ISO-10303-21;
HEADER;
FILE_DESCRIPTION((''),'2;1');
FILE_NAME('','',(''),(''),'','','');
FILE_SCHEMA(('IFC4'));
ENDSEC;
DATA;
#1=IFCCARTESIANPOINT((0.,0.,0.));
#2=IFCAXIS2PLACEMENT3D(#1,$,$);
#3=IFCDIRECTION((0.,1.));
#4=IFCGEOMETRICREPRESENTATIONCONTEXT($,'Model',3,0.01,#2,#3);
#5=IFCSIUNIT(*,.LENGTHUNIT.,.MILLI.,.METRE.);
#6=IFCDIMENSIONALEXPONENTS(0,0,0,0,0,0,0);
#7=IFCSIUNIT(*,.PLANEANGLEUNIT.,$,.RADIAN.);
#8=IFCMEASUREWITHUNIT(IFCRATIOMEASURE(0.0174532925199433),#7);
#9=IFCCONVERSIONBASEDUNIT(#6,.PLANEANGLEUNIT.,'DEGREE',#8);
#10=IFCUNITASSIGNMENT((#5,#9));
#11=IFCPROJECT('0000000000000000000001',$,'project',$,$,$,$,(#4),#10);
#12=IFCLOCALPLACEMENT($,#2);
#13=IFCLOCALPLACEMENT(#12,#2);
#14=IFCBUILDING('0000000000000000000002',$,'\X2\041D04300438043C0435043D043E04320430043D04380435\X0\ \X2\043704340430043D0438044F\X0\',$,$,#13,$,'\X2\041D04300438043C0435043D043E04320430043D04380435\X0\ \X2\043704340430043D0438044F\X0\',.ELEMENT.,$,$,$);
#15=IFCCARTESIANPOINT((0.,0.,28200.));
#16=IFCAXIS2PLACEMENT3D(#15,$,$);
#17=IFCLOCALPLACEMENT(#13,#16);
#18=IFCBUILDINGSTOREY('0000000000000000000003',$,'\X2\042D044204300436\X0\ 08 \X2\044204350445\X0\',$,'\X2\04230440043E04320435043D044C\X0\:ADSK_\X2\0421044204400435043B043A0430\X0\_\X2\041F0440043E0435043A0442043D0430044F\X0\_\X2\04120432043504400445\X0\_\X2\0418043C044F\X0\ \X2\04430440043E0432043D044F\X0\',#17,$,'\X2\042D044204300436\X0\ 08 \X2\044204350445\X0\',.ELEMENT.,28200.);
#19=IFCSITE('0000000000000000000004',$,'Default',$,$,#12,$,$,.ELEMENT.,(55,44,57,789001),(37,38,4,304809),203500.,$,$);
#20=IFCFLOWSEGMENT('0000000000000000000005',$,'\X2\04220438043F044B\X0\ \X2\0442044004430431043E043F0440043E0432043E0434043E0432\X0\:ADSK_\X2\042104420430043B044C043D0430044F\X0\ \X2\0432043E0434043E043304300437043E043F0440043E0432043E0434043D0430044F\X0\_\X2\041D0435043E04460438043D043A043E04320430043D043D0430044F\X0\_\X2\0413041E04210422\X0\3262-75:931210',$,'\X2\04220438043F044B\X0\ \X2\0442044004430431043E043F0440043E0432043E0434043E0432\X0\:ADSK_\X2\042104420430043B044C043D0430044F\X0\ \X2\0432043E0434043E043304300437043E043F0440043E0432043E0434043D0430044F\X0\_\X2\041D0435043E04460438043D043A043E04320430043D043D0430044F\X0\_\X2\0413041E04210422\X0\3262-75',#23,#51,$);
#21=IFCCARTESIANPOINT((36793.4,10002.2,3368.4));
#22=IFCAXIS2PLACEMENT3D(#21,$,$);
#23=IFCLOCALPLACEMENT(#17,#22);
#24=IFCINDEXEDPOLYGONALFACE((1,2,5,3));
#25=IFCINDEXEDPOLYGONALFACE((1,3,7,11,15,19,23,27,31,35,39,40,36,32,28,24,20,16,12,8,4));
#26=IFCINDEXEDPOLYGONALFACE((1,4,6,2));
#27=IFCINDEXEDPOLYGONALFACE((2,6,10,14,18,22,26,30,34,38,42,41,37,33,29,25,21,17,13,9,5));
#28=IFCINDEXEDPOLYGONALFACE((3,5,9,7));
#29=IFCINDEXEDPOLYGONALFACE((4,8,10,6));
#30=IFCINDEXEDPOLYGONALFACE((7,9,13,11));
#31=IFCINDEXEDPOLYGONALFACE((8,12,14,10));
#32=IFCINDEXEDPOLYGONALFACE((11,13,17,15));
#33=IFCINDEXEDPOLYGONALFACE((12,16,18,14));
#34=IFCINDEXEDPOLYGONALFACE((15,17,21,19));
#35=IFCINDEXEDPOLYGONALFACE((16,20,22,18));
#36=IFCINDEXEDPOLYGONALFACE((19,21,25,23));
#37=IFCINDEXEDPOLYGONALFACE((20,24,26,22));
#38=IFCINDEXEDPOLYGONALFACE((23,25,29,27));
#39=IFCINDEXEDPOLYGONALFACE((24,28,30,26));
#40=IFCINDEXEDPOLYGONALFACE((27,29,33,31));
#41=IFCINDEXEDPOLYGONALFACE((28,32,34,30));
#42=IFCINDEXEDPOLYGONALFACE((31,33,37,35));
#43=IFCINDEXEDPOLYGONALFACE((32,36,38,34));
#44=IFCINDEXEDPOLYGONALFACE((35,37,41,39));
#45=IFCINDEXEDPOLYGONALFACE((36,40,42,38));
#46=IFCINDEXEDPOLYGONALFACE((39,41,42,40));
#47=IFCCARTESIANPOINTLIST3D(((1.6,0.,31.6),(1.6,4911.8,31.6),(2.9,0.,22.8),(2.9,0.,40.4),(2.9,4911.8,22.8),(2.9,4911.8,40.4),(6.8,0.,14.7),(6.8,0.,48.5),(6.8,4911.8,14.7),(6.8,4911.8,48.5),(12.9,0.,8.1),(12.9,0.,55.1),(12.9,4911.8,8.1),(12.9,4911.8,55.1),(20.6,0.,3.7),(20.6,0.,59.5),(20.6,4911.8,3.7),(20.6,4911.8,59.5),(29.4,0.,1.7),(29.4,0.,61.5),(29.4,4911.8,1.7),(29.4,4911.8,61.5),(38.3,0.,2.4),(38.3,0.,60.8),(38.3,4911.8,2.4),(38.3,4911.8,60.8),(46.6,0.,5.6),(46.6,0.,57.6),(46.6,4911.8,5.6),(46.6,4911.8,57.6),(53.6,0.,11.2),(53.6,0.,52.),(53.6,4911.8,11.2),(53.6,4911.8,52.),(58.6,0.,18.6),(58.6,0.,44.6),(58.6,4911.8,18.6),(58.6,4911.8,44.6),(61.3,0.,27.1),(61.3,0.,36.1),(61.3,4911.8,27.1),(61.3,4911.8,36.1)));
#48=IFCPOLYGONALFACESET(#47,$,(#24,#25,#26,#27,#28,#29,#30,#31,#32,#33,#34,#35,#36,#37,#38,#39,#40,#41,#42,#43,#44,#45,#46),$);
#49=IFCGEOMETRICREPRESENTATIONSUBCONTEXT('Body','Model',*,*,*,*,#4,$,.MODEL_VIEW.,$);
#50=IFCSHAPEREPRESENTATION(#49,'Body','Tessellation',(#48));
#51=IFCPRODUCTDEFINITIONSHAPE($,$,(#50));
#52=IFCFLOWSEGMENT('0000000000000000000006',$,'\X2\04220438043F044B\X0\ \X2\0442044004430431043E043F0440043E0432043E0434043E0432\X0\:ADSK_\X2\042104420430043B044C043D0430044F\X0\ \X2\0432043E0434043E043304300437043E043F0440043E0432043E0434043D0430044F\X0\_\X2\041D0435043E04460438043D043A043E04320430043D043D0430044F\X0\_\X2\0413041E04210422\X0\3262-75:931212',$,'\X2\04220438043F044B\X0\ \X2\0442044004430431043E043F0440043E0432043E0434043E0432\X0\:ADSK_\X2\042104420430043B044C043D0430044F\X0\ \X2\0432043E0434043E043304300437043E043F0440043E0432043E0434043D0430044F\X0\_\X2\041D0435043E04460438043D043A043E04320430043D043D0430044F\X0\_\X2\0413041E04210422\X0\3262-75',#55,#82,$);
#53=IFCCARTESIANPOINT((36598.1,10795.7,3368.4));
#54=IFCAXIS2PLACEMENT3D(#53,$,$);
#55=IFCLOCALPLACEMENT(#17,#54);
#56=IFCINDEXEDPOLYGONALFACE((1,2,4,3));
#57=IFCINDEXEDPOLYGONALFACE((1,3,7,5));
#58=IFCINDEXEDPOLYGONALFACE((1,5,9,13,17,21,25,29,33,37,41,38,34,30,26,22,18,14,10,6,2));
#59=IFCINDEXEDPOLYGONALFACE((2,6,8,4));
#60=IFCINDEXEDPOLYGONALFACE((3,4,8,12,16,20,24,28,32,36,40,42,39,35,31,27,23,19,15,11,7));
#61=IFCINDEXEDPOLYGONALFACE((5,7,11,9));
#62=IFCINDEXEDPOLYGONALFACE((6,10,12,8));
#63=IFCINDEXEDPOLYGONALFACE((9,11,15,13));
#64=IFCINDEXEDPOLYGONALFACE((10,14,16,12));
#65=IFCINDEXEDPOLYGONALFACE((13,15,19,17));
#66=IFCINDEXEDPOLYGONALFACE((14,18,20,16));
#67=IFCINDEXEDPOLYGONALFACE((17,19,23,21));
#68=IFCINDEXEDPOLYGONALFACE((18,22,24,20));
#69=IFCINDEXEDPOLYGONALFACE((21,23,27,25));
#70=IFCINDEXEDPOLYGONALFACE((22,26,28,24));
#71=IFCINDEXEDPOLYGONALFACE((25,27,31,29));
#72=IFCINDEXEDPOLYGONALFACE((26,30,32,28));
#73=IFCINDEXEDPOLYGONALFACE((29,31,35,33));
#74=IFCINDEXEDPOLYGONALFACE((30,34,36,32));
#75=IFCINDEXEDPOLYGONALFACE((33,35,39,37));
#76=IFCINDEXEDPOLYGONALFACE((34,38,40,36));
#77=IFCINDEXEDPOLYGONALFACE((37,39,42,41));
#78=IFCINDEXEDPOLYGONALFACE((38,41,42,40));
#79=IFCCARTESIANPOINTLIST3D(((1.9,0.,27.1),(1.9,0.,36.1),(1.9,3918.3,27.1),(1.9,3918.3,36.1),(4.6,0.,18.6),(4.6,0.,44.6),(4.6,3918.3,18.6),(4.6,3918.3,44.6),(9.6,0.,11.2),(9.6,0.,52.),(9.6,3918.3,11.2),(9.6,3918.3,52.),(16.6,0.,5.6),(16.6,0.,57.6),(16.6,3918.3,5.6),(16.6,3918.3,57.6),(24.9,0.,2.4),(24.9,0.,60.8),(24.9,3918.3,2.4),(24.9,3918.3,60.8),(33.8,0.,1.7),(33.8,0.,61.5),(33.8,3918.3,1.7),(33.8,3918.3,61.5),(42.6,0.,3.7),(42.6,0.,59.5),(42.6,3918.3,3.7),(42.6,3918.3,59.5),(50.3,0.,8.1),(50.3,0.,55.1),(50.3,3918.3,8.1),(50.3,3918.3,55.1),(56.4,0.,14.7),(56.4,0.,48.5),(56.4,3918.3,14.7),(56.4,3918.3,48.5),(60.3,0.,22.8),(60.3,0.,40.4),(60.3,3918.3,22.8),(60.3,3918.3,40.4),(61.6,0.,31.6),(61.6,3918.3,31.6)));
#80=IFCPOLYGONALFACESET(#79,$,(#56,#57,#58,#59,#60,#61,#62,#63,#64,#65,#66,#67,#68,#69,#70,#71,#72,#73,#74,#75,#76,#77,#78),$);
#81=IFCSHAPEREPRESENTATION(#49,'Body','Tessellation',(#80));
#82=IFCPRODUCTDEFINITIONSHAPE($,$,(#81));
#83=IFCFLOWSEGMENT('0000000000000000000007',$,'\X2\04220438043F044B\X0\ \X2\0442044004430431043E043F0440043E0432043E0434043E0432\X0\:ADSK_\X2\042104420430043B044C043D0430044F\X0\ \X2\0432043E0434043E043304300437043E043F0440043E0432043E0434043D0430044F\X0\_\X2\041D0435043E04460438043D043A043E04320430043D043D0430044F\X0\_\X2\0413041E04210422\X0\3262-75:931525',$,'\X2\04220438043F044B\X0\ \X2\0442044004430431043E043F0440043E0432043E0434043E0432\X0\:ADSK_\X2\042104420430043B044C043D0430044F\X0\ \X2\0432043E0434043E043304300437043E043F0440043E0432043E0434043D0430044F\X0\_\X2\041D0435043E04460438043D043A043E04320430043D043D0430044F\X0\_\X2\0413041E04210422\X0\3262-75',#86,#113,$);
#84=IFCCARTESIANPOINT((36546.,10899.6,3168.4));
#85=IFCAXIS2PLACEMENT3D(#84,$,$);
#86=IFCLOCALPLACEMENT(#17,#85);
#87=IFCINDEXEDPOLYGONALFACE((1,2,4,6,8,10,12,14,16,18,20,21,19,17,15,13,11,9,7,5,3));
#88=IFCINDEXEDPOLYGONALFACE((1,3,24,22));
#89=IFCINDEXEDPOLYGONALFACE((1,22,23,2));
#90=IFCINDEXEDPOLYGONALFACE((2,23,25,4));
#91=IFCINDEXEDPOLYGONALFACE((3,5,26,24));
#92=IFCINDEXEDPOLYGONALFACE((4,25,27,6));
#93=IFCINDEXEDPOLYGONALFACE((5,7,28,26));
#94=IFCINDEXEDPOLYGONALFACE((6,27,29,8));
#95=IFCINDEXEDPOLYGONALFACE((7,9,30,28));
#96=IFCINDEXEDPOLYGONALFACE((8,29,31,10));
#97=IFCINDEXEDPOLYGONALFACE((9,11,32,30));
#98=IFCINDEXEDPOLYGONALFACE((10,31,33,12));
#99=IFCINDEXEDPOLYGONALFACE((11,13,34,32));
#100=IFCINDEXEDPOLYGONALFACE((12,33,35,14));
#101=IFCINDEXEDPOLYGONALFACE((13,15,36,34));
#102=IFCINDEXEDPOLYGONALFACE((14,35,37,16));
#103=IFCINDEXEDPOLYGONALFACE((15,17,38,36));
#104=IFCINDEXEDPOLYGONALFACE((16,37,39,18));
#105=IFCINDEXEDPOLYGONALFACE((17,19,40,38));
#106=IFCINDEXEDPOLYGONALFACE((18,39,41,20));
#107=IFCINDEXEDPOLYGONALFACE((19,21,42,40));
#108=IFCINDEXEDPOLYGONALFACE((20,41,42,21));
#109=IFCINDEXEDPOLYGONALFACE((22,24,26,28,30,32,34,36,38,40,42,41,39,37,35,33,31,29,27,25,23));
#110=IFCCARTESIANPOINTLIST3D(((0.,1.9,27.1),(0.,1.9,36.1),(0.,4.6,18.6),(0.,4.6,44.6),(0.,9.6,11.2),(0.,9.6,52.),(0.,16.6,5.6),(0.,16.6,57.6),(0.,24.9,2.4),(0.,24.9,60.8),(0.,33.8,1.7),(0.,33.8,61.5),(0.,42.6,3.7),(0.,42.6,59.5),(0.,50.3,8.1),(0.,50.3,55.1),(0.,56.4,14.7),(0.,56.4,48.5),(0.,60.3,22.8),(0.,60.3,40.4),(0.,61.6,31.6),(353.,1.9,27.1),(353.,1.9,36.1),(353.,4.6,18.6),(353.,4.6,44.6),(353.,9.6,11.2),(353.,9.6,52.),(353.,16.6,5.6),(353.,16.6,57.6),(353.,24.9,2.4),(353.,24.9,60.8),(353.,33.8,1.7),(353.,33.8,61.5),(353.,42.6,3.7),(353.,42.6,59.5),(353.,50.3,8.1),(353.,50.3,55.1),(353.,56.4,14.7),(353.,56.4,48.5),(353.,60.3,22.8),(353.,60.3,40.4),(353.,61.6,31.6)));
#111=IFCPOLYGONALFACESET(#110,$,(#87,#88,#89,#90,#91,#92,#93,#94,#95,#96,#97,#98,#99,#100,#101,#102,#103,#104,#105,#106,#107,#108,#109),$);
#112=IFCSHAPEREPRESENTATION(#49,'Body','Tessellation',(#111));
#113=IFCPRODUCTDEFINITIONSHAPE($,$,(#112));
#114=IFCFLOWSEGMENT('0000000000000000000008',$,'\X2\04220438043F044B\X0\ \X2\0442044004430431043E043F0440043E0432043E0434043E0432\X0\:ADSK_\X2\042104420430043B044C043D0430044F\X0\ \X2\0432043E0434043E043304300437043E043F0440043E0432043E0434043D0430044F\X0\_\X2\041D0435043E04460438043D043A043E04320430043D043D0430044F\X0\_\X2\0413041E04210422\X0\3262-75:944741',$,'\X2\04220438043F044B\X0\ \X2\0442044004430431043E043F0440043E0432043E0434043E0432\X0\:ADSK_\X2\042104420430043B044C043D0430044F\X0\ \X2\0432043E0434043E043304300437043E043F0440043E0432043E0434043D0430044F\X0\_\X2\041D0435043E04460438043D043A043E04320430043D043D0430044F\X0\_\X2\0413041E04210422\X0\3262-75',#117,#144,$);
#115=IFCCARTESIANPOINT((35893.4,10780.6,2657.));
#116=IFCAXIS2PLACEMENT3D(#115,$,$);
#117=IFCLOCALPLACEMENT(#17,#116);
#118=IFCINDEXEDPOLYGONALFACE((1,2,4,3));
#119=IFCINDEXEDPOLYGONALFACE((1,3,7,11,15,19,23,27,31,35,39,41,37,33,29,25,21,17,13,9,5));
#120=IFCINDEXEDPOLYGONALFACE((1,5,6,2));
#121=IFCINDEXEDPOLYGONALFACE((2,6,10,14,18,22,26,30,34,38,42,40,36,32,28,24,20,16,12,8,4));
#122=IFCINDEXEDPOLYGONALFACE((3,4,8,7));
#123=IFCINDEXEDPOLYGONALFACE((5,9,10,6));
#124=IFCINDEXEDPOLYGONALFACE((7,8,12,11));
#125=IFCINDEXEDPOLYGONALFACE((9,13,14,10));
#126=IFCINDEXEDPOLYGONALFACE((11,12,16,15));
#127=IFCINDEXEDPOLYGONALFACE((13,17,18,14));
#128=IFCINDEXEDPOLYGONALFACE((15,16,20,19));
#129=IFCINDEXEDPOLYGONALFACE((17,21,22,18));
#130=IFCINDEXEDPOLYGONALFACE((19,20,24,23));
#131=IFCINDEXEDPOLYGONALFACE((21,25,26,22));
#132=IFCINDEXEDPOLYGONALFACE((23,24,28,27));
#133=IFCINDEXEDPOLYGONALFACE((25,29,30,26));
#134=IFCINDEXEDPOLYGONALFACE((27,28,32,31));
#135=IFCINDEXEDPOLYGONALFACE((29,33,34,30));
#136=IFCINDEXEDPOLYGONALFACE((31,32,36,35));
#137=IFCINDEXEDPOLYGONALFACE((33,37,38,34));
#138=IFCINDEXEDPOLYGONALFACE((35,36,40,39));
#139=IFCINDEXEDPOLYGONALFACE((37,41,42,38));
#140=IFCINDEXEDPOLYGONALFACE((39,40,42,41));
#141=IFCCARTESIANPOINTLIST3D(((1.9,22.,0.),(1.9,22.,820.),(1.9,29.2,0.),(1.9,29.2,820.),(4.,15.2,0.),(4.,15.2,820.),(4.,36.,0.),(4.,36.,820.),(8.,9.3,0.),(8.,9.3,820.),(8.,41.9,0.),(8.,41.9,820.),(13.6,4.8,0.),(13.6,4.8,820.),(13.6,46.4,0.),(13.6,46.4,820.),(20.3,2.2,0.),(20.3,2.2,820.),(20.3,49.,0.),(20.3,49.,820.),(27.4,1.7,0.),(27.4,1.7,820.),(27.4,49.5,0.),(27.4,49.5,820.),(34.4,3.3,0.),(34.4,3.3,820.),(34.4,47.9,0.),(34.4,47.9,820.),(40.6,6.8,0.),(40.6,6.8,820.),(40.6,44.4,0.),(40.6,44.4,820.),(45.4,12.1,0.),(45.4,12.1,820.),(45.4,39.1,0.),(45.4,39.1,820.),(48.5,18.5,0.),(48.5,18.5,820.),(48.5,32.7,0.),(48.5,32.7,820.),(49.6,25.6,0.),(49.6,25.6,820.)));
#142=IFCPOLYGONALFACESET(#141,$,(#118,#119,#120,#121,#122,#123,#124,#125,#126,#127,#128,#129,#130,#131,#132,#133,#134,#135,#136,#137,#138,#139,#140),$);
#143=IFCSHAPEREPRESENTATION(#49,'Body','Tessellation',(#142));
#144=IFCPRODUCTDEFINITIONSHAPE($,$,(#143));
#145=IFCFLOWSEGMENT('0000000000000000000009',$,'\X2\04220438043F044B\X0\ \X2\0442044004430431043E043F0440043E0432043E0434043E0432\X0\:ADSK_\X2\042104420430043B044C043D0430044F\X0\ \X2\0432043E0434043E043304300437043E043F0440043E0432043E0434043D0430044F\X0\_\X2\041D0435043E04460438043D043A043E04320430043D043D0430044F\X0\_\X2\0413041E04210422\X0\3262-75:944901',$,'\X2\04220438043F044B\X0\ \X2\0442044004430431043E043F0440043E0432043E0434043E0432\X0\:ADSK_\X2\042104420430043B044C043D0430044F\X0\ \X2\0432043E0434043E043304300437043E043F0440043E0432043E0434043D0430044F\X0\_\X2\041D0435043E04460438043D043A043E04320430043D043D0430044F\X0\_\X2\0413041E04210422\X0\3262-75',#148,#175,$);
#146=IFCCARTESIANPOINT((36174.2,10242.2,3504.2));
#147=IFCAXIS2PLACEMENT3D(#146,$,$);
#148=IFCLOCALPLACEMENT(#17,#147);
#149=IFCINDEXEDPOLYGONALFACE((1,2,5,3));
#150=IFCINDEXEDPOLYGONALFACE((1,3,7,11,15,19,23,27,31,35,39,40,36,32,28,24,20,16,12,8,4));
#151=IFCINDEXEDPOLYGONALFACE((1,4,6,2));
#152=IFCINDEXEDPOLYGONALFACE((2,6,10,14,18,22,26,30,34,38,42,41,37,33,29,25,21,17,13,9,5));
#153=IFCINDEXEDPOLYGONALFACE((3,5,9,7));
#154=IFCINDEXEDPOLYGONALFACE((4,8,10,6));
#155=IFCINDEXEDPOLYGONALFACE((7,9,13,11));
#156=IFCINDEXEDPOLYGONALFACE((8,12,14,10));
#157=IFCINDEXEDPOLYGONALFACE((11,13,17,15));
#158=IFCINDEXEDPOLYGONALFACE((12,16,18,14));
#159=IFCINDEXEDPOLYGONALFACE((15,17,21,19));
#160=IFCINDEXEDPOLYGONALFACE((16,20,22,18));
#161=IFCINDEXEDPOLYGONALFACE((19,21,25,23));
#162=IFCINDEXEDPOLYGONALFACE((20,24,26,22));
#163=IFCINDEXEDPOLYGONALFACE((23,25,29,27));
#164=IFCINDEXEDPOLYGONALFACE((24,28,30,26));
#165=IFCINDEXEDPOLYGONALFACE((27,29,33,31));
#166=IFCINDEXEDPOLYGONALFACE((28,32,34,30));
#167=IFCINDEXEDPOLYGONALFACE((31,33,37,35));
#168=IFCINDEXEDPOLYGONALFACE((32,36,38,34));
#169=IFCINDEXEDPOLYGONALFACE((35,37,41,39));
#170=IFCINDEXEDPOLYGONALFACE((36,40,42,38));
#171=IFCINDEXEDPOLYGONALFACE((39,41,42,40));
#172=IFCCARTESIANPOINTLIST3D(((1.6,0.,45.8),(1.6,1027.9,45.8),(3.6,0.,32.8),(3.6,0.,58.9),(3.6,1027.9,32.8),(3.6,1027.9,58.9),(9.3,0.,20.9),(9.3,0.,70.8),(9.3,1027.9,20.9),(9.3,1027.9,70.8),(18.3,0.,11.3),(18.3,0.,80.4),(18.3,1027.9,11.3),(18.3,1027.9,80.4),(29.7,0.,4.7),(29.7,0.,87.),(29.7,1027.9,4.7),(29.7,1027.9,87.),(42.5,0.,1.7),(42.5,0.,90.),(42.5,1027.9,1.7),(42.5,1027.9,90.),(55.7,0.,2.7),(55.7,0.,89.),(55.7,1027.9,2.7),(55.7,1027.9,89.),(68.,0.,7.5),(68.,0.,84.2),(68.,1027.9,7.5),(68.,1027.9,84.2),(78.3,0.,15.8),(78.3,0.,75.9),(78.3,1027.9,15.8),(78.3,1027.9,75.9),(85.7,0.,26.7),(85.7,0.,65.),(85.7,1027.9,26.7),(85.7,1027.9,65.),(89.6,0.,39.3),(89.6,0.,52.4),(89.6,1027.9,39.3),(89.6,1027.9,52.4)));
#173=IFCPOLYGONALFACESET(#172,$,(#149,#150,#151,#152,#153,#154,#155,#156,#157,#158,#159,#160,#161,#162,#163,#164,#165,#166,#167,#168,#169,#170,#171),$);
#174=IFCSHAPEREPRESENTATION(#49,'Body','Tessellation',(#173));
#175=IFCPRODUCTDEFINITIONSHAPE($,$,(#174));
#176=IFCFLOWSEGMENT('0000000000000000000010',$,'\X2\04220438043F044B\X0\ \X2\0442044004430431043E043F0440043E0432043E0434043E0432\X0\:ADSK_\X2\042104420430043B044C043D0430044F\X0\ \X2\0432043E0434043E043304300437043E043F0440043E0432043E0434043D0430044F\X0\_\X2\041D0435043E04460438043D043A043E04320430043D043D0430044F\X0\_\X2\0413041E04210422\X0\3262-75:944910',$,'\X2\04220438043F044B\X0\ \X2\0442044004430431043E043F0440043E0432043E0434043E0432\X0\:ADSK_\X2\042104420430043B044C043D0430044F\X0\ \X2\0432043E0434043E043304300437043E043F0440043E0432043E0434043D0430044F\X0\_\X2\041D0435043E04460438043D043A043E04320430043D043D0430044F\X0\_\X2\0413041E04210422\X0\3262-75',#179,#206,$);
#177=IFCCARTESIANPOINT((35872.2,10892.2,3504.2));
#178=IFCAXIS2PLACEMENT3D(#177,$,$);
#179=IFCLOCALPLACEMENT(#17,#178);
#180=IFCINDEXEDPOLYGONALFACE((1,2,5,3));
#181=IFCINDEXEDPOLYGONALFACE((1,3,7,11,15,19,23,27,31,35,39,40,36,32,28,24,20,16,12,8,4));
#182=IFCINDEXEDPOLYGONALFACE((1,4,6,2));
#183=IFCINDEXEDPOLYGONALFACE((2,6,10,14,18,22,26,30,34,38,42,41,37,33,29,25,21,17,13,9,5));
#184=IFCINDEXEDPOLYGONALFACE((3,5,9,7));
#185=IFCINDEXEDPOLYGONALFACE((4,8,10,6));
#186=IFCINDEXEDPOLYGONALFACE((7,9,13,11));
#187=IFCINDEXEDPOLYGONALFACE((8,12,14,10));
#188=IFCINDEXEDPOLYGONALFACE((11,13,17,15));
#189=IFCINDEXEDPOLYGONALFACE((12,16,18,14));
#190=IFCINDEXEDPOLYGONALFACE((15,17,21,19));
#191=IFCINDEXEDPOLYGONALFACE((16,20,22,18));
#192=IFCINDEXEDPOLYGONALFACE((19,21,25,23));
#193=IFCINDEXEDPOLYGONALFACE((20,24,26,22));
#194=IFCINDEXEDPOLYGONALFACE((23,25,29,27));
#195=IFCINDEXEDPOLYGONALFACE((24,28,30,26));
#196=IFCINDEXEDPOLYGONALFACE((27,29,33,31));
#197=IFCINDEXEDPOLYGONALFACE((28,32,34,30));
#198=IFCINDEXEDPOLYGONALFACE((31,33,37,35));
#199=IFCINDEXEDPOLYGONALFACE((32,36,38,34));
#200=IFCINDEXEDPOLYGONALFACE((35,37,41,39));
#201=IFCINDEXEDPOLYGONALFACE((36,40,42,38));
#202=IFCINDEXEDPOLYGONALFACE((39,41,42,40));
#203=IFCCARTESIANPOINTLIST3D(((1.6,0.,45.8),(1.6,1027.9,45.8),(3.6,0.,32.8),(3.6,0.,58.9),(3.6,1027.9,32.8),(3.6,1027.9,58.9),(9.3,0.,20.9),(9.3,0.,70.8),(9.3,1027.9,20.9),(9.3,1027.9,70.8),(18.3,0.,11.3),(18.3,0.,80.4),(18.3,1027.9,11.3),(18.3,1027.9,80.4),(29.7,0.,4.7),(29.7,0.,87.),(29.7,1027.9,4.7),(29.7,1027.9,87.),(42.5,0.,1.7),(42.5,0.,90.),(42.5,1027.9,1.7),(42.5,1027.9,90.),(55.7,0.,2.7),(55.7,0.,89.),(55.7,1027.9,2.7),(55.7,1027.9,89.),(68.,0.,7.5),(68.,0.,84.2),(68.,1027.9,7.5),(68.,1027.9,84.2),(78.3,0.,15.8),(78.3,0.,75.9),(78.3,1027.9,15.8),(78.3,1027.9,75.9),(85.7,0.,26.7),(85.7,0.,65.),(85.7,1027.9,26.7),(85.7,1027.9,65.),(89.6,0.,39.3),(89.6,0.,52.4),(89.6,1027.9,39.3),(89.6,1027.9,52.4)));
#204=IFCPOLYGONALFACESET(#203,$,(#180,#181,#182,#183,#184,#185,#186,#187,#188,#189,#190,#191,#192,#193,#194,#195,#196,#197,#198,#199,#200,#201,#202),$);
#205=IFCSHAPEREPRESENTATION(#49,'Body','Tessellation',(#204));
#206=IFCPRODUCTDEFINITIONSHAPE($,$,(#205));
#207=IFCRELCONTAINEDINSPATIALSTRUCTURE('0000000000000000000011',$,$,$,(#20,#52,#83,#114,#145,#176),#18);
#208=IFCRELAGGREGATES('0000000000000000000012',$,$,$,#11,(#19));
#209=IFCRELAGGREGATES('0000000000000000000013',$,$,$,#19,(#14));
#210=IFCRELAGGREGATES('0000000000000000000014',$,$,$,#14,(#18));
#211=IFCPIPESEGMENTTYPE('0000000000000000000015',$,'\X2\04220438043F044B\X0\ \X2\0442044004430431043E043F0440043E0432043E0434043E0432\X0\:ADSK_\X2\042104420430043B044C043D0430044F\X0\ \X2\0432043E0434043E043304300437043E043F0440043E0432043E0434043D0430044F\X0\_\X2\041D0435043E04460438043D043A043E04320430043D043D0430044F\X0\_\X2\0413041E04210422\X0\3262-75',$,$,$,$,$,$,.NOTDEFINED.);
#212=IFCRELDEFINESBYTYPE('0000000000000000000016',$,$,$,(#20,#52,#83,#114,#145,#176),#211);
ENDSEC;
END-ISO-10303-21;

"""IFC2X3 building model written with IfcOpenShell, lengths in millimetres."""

from ifc_helpers import new_model, entity, si_unit, converted_unit, direction, frame, origin, origin_2d_with_axis, place, context, subcontext, project, spatial, circle, extrude, type_object, element, save


model = new_model("IFC2X3")

# Units and contexts
model_context = context("Model", 3, precision=0.01, world=origin(), true_north=direction((0.0, 1.0)))
body_context = subcontext(model_context, "Body", "Model", "MODEL_VIEW")
ifc_project = project(units=[si_unit("LENGTHUNIT", "METRE", prefix="MILLI"), converted_unit("PLANEANGLEUNIT", "DEGREE", entity("IfcRatioMeasure", 0.0174532925199433), si_unit("PLANEANGLEUNIT", "RADIAN"), dimensions=[0, 0, 0, 0, 0, 0, 0])], contexts=[model_context])

# Site, building, storey
site_placement = place(None, origin())
site = spatial("IfcSite", under=ifc_project, at=site_placement, Name="Default", CompositionType="ELEMENT", RefLatitude=(55, 44, 57, 789001), RefLongitude=(37, 38, 4, 304809), RefElevation=203500.0)
building_placement = place(site_placement, origin())
building = spatial("IfcBuilding", under=site, at=building_placement, Name="Наименование здания", LongName="Наименование здания", CompositionType="ELEMENT")
storey_placement = place(building_placement, frame((0.0, 0.0, 28200.0)))
storey = spatial("IfcBuildingStorey", under=building, at=storey_placement, Name="Этаж 08 тех", ObjectType="Уровень:ADSK_Стрелка_Проектная_Вверх_Имя уровня", LongName="Этаж 08 тех", CompositionType="ELEMENT", Elevation=28200.0)

# Flow segments
pipe_segment_type = type_object("IfcPipeSegmentType", Name="Типы трубопроводов:ADSK_Стальная водогазопроводная_Неоцинкованная_ГОСТ3262-75", PredefinedType="NOTDEFINED")
flow_segment_1_placement = place(storey_placement, frame((36793.4, 10002.2, 3368.4)))
element("IfcFlowSegment", 1, at=flow_segment_1_placement, inside=storey, type_object=pipe_segment_type, Name="Типы трубопроводов:ADSK_Стальная водогазопроводная_Неоцинкованная_ГОСТ3262-75:931210", ObjectType="Типы трубопроводов:ADSK_Стальная водогазопроводная_Неоцинкованная_ГОСТ3262-75", context=body_context, shape_type="SweptSolid", body=[
    extrude(circle(Radius=30.0, at=origin_2d_with_axis()), frame((31.6, 0.0, 31.6), z_axis=(0.0, 1.0, 0.0), x_axis=(-1.0, 0.0, 0.0)), (0.0, 0.0, 1.0), 4911.8),
])
flow_segment_2_placement = place(storey_placement, frame((36598.1, 10795.7, 3368.4)))
element("IfcFlowSegment", 2, at=flow_segment_2_placement, inside=storey, type_object=pipe_segment_type, Name="Типы трубопроводов:ADSK_Стальная водогазопроводная_Неоцинкованная_ГОСТ3262-75:931212", ObjectType="Типы трубопроводов:ADSK_Стальная водогазопроводная_Неоцинкованная_ГОСТ3262-75", context=body_context, shape_type="SweptSolid", body=[
    extrude(circle(Radius=30.0, at=origin_2d_with_axis()), frame((31.6, 0.0, 31.6), z_axis=(0.0, 1.0, 0.0), x_axis=(1.0, 0.0, 0.0)), (0.0, 0.0, 1.0), 3918.3),
])
flow_segment_3_placement = place(storey_placement, frame((36546.0, 10899.6, 3168.4)))
element("IfcFlowSegment", 3, at=flow_segment_3_placement, inside=storey, type_object=pipe_segment_type, Name="Типы трубопроводов:ADSK_Стальная водогазопроводная_Неоцинкованная_ГОСТ3262-75:931525", ObjectType="Типы трубопроводов:ADSK_Стальная водогазопроводная_Неоцинкованная_ГОСТ3262-75", context=body_context, shape_type="SweptSolid", body=[
    extrude(circle(Radius=30.0, at=origin_2d_with_axis()), frame((0.0, 31.6, 31.6), z_axis=(1.0, 0.0, 0.0), x_axis=(0.0, 1.0, 0.0)), (0.0, 0.0, 1.0), 353.0),
])
flow_segment_4_placement = place(storey_placement, frame((35893.4, 10780.6, 2657.0)))
element("IfcFlowSegment", 4, at=flow_segment_4_placement, inside=storey, type_object=pipe_segment_type, Name="Типы трубопроводов:ADSK_Стальная водогазопроводная_Неоцинкованная_ГОСТ3262-75:944741", ObjectType="Типы трубопроводов:ADSK_Стальная водогазопроводная_Неоцинкованная_ГОСТ3262-75", context=body_context, shape_type="SweptSolid", body=[
    extrude(circle(Radius=24.0, at=origin_2d_with_axis()), frame((25.6, 25.6, 0.0)), (0.0, 0.0, 1.0), 820.0),
])
flow_segment_5_placement = place(storey_placement, frame((36174.2, 10242.2, 3504.2)))
element("IfcFlowSegment", 5, at=flow_segment_5_placement, inside=storey, type_object=pipe_segment_type, Name="Типы трубопроводов:ADSK_Стальная водогазопроводная_Неоцинкованная_ГОСТ3262-75:944901", ObjectType="Типы трубопроводов:ADSK_Стальная водогазопроводная_Неоцинкованная_ГОСТ3262-75", context=body_context, shape_type="SweptSolid", body=[
    extrude(circle(Radius=44.2, at=origin_2d_with_axis()), frame((45.9, 0.0, 45.9), z_axis=(0.0, 1.0, 0.0), x_axis=(-1.0, 0.0, 0.0)), (0.0, 0.0, 1.0), 1027.9),
])
flow_segment_6_placement = place(storey_placement, frame((35872.2, 10892.2, 3504.2)))
element("IfcFlowSegment", 6, at=flow_segment_6_placement, inside=storey, type_object=pipe_segment_type, Name="Типы трубопроводов:ADSK_Стальная водогазопроводная_Неоцинкованная_ГОСТ3262-75:944910", ObjectType="Типы трубопроводов:ADSK_Стальная водогазопроводная_Неоцинкованная_ГОСТ3262-75", context=body_context, shape_type="SweptSolid", body=[
    extrude(circle(Radius=44.2, at=origin_2d_with_axis()), frame((45.9, 0.0, 45.9), z_axis=(0.0, 1.0, 0.0), x_axis=(-1.0, 0.0, 0.0)), (0.0, 0.0, 1.0), 1027.9),
])

save(model, "model.ifc")
